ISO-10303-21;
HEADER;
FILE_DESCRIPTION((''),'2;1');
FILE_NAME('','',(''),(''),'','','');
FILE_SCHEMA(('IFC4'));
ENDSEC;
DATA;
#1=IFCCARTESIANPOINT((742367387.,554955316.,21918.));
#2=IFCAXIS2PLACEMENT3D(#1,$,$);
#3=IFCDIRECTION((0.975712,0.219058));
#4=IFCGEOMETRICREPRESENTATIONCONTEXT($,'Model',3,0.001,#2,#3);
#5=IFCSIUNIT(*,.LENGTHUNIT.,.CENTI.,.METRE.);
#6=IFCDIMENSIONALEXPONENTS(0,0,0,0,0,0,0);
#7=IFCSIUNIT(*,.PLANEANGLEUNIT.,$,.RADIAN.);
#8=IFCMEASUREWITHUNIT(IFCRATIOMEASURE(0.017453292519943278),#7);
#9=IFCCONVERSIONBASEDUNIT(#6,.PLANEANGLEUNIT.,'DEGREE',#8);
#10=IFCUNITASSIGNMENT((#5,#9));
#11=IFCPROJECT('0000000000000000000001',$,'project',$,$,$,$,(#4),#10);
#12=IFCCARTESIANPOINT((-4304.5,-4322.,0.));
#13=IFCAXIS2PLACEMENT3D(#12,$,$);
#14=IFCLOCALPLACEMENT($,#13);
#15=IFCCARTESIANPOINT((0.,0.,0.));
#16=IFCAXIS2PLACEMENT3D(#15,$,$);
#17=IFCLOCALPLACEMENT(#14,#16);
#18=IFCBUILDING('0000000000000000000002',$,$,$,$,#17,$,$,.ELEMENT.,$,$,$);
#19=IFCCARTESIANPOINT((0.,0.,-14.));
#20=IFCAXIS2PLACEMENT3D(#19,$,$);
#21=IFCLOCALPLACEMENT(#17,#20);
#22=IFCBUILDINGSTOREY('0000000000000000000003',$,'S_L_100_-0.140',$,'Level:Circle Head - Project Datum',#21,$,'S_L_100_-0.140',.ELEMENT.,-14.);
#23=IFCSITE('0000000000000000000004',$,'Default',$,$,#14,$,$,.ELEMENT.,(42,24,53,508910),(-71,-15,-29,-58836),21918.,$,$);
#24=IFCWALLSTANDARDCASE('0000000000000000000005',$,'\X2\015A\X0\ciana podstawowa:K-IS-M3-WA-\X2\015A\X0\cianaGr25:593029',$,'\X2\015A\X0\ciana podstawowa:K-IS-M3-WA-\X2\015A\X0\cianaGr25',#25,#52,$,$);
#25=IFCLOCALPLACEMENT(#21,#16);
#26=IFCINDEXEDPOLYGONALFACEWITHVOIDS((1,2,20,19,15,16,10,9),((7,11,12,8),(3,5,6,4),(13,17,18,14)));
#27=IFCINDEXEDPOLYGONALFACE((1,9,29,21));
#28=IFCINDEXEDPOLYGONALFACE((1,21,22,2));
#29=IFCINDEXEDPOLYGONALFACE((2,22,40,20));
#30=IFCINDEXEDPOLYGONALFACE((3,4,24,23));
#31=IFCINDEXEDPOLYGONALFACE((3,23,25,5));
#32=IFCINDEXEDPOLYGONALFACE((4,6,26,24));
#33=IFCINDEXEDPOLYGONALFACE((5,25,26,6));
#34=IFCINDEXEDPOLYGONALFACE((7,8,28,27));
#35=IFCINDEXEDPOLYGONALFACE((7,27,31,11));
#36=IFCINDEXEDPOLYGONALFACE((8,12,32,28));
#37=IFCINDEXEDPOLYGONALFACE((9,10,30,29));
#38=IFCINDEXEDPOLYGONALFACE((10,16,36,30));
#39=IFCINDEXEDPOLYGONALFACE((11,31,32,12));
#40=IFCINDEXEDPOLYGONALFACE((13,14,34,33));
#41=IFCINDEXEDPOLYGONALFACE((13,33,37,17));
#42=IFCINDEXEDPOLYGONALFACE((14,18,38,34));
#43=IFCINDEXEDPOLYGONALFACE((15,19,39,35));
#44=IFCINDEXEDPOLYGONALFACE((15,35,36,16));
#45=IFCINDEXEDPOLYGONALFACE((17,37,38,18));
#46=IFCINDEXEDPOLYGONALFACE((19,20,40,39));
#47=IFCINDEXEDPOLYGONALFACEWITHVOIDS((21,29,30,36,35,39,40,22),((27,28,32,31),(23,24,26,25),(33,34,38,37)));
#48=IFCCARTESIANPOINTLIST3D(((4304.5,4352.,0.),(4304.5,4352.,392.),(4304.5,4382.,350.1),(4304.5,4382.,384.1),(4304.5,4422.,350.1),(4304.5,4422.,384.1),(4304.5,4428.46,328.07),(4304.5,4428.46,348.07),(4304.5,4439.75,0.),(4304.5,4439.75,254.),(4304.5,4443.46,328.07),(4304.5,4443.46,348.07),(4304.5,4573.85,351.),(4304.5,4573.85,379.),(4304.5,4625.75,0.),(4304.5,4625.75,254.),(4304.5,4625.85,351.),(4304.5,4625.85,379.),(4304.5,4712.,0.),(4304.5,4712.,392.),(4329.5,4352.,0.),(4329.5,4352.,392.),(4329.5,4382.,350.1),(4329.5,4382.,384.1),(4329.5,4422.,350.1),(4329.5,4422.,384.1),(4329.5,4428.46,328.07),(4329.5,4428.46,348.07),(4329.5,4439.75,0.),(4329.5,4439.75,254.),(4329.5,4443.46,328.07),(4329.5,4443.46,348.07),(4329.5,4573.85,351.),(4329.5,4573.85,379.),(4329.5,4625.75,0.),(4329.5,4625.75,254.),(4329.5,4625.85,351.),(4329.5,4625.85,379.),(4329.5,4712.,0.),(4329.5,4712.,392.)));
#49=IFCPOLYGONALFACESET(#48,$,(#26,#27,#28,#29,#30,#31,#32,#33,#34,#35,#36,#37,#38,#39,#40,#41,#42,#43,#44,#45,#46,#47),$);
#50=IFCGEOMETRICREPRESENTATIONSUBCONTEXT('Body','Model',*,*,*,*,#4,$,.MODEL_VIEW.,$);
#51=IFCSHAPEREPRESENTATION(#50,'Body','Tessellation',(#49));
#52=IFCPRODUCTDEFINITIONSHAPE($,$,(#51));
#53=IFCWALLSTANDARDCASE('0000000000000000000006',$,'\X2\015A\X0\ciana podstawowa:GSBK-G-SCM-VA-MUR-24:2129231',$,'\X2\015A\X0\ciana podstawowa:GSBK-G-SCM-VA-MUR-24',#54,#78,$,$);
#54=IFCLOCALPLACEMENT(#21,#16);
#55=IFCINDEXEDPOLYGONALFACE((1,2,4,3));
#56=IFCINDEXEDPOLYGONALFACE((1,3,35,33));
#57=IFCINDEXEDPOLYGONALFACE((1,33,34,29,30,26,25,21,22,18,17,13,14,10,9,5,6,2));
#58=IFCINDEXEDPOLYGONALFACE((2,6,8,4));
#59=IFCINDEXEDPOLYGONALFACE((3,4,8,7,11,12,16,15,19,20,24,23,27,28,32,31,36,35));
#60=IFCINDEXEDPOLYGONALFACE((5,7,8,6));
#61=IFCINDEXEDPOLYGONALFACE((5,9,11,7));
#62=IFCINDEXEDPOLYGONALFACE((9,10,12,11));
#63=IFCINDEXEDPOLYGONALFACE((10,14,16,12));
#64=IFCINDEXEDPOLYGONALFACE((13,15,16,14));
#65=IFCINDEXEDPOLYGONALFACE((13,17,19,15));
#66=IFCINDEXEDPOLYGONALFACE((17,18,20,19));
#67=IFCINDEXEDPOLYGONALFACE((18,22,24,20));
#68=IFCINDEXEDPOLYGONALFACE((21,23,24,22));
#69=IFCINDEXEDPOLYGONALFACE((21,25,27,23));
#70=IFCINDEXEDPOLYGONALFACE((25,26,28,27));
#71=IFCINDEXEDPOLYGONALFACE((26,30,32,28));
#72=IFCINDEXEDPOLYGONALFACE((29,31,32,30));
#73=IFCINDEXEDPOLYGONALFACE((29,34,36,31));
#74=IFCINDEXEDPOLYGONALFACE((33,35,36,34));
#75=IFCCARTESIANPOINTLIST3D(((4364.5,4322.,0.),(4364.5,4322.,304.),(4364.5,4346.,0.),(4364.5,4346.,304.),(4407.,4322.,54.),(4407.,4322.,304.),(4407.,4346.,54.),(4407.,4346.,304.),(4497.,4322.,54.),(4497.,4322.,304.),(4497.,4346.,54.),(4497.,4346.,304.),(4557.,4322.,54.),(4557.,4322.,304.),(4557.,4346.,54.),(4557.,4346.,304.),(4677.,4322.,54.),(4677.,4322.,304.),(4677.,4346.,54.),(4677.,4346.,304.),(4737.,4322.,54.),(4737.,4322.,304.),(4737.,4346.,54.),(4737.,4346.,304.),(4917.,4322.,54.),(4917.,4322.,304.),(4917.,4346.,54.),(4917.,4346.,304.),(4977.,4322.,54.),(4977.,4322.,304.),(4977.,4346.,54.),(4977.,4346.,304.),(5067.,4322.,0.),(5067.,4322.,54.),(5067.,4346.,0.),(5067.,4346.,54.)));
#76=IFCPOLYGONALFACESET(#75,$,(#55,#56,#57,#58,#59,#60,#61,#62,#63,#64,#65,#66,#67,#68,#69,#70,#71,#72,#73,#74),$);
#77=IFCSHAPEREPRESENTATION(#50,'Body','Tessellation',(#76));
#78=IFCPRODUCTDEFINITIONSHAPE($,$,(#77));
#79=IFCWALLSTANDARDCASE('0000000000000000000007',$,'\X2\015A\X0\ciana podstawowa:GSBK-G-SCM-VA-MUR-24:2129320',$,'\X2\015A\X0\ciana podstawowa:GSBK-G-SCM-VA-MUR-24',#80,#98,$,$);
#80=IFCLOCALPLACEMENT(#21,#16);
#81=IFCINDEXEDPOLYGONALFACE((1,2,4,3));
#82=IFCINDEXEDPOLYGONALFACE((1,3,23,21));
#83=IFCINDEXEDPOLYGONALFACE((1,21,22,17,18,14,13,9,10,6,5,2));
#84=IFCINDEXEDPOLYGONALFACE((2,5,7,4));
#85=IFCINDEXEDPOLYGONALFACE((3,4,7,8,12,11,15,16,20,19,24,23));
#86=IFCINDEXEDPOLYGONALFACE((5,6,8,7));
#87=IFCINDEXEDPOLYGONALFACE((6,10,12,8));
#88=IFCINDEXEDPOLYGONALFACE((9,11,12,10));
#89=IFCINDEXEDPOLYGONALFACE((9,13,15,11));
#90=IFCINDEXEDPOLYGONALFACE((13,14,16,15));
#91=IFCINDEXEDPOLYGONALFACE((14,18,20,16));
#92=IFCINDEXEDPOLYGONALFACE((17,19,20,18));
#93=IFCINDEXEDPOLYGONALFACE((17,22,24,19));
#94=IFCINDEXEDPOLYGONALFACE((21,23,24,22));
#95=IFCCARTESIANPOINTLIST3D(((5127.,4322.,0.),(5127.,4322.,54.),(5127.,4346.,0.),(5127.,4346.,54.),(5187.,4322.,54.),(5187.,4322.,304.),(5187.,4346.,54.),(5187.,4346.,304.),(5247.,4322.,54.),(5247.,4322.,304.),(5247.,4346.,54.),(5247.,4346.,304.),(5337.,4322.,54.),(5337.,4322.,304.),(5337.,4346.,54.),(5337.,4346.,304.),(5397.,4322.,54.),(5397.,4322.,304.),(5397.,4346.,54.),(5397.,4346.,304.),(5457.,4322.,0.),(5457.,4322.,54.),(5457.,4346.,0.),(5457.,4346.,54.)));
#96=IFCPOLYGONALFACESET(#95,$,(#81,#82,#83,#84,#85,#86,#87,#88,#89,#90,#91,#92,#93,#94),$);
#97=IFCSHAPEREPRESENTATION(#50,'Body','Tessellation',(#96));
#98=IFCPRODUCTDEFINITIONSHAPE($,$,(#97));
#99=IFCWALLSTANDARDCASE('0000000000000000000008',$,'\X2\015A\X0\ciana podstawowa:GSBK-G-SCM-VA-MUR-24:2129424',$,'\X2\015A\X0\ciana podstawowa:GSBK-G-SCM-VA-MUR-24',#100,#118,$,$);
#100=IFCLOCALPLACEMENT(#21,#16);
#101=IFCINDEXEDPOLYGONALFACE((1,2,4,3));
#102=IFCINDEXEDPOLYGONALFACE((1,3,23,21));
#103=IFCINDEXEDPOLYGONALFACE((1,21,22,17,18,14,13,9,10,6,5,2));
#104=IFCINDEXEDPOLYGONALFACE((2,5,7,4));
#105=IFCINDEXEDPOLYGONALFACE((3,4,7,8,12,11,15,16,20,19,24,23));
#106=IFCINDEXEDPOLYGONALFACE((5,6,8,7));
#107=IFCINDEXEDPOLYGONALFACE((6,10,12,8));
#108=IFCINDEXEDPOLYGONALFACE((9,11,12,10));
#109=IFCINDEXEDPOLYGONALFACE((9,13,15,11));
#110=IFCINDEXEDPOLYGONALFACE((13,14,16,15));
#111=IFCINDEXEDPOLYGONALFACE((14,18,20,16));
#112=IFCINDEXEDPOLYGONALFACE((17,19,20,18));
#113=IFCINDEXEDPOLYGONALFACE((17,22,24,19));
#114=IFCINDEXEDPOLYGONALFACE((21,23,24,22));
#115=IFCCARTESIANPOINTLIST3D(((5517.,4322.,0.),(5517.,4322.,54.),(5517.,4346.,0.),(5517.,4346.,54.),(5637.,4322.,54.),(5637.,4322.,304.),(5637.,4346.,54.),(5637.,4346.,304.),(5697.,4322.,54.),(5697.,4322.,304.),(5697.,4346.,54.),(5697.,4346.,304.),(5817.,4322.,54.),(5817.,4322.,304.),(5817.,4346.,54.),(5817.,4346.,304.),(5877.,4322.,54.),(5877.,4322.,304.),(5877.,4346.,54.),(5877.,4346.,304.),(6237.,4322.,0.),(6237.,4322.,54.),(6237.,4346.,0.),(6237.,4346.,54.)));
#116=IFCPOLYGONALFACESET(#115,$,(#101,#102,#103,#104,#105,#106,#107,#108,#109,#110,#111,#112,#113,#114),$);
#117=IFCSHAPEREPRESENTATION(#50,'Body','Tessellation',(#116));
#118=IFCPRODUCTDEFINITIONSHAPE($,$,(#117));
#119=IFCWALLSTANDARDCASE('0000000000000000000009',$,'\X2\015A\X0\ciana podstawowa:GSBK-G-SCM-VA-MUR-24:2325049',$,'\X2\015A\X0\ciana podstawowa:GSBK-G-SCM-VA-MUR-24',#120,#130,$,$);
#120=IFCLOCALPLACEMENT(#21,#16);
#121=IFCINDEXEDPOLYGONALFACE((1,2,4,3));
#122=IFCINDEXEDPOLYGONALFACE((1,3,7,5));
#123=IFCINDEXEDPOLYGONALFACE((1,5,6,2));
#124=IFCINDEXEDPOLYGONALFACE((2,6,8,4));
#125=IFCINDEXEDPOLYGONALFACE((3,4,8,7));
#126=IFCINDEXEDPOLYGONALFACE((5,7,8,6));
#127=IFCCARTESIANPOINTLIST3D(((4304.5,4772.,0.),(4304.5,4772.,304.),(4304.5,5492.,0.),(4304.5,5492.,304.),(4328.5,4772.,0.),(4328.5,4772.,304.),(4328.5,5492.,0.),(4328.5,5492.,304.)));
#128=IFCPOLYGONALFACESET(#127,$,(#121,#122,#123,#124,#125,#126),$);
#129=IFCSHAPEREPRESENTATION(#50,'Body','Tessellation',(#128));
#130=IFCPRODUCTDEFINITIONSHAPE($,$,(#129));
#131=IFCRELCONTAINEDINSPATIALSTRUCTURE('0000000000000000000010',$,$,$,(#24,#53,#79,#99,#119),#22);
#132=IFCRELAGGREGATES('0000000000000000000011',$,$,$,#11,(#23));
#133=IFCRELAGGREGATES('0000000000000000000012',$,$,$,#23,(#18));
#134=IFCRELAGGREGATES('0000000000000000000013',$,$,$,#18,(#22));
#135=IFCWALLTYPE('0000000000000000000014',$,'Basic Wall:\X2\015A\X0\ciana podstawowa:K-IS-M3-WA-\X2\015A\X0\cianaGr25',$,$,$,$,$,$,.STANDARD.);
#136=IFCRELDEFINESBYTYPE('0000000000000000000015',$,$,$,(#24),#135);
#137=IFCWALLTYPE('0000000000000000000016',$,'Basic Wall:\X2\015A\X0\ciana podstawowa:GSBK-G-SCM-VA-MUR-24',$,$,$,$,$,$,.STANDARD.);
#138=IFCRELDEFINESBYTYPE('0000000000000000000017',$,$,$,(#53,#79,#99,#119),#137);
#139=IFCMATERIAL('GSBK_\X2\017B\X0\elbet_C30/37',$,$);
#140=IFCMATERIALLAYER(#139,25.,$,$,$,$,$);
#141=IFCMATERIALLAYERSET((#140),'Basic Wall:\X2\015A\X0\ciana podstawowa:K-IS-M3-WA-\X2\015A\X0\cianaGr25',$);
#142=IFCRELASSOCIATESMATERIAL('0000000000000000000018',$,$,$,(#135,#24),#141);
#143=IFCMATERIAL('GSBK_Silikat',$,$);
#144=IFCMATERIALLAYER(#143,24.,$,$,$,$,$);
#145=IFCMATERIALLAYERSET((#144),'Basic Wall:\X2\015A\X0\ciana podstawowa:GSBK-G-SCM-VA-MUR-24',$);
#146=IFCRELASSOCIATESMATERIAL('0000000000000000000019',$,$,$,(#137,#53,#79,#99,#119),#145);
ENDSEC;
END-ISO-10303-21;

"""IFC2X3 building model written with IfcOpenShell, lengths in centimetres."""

from ifc_helpers import new_model, entity, si_unit, converted_unit, direction, frame, frame_2d, origin, origin_2d_with_axis, place, context, subcontext, project, spatial, rectangle, extrude, material, layer, layer_set, layer_usage, type_object, element, save


model = new_model("IFC2X3")

# Units and contexts
model_context = context("Model", 3, precision=0.001, world=frame((742367387.0, 554955316.0, 21918.0)), true_north=direction((0.975712, 0.219058)))
body_context = subcontext(model_context, "Body", "Model", "MODEL_VIEW")
ifc_project = project(units=[si_unit("LENGTHUNIT", "METRE", prefix="CENTI"), converted_unit("PLANEANGLEUNIT", "DEGREE", entity("IfcRatioMeasure", 0.017453292519943278), si_unit("PLANEANGLEUNIT", "RADIAN"), dimensions=[0, 0, 0, 0, 0, 0, 0])], contexts=[model_context])

# Site, building, storey
site_placement = place(None, frame((-4304.5, -4322.0, 0.0)))
site = spatial("IfcSite", under=ifc_project, at=site_placement, Name="Default", CompositionType="ELEMENT", RefLatitude=(42, 24, 53, 508910), RefLongitude=(-71, -15, -29, -58836), RefElevation=21918.0)
building_placement = place(site_placement, origin())
building = spatial("IfcBuilding", under=site, at=building_placement, CompositionType="ELEMENT")
storey_placement = place(building_placement, frame((0.0, 0.0, -14.0)))
storey = spatial("IfcBuildingStorey", under=building, at=storey_placement, Name="S_L_100_-0.140", ObjectType="Level:Circle Head - Project Datum", LongName="S_L_100_-0.140", CompositionType="ELEMENT", Elevation=-14.0)

# Shared definitions
ifc_material_1 = material(Name="GSBK_Żelbet_C30/37")

# Walls, openings
ifc_layer_1 = layer(ifc_material_1, 25.0)
ifc_layer_set_1 = layer_set([ifc_layer_1], Name="Basic Wall:Ściana podstawowa:K-IS-M3-WA-ŚcianaGr25")
ifc_layer_usage_1 = layer_usage(ifc_layer_set_1, "AXIS2", "NEGATIVE", 12.5)
wall_type_1 = type_object("IfcWallType", Name="Basic Wall:Ściana podstawowa:K-IS-M3-WA-ŚcianaGr25", PredefinedType="STANDARD", material=ifc_layer_set_1)
wall_1_placement = place(storey_placement, frame((4317.0, 4712.0, 0.0), z_axis=(0.0, 0.0, 1.0), x_axis=(0.0, -1.0, 0.0)))
wall_1 = element("IfcWallStandardCase", 1, at=wall_1_placement, inside=storey, type_object=wall_type_1, material=ifc_layer_usage_1, Name="Ściana podstawowa:K-IS-M3-WA-ŚcianaGr25:593029", ObjectType="Ściana podstawowa:K-IS-M3-WA-ŚcianaGr25", context=body_context, shape_type="SweptSolid", body=[
    extrude(rectangle(XDim=360.0, YDim=25.0, at=frame_2d((180.0, 0.0), x_axis=(-1.0, 0.0))), origin(), (0.0, 0.0, 1.0), 392.0),
])
opening_1_placement = place(wall_1_placement, frame((272.25, -12.5, 0.0)))
element("IfcOpeningElement", 2, at=opening_1_placement, cuts=wall_1, ObjectType="Opening", context=body_context, shape_type="SweptSolid", body=[
    extrude(rectangle(XDim=254.0, YDim=186.0, at=origin_2d_with_axis()), frame((-93.0, 0.0, 127.0), z_axis=(0.0, 1.0, 0.0), x_axis=(0.0, 0.0, -1.0)), (0.0, 0.0, 1.0), 25.0),
])
opening_2_placement = place(wall_1_placement, frame((138.15, -12.5, 351.0)))
element("IfcOpeningElement", 3, at=opening_2_placement, cuts=wall_1, ObjectType="Opening", context=body_context, shape_type="SweptSolid", body=[
    extrude(rectangle(XDim=28.0, YDim=52.0, at=frame_2d((0.0, 0.0), x_axis=(1.0, 0.0))), frame((-26.0, 0.0, 14.0), z_axis=(0.0, 1.0, 0.0), x_axis=(0.0, 0.0, -1.0)), (0.0, 0.0, 1.0), 25.0),
])
opening_3_placement = place(wall_1_placement, frame((330.0, -12.5, 350.1)))
element("IfcOpeningElement", 4, at=opening_3_placement, cuts=wall_1, ObjectType="Opening", context=body_context, shape_type="SweptSolid", body=[
    extrude(rectangle(XDim=34.0, YDim=40.0, at=frame_2d((0.0, 0.0), x_axis=(1.0, 0.0))), frame((-20.0, 0.0, 17.0), z_axis=(0.0, 1.0, 0.0), x_axis=(0.0, 0.0, -1.0)), (0.0, 0.0, 1.0), 25.0),
])
opening_4_placement = place(wall_1_placement, frame((283.54, -12.5, 328.07)))
element("IfcOpeningElement", 5, at=opening_4_placement, cuts=wall_1, ObjectType="Opening", context=body_context, shape_type="SweptSolid", body=[
    extrude(rectangle(XDim=20.0, YDim=15.0, at=frame_2d((0.0, 0.0), x_axis=(1.0, 0.0))), frame((-7.5, 0.0, 10.0), z_axis=(0.0, 1.0, 0.0), x_axis=(0.0, 0.0, -1.0)), (0.0, 0.0, 1.0), 25.0),
])
ifc_material_2 = material(Name="GSBK_Silikat")
ifc_layer_2 = layer(ifc_material_2, 24.0)
ifc_layer_set_2 = layer_set([ifc_layer_2], Name="Basic Wall:Ściana podstawowa:GSBK-G-SCM-VA-MUR-24")
ifc_layer_usage_2 = layer_usage(ifc_layer_set_2, "AXIS2", "NEGATIVE", 12.0)
wall_type_2 = type_object("IfcWallType", Name="Basic Wall:Ściana podstawowa:GSBK-G-SCM-VA-MUR-24", PredefinedType="STANDARD", material=ifc_layer_set_2)
wall_2_placement = place(storey_placement, frame((4364.5, 4334.0, 0.0)))
wall_2 = element("IfcWallStandardCase", 6, at=wall_2_placement, inside=storey, type_object=wall_type_2, material=ifc_layer_usage_2, Name="Ściana podstawowa:GSBK-G-SCM-VA-MUR-24:2129231", ObjectType="Ściana podstawowa:GSBK-G-SCM-VA-MUR-24", context=body_context, shape_type="SweptSolid", body=[
    extrude(rectangle(XDim=702.5, YDim=24.0, at=frame_2d((351.25, 0.0), x_axis=(-1.0, 0.0))), origin(), (0.0, 0.0, 1.0), 304.0),
])
opening_5_placement = place(wall_2_placement, frame((192.5, -12.0, 54.0)))
element("IfcOpeningElement", 7, at=opening_5_placement, cuts=wall_2, ObjectType="Opening", context=body_context, shape_type="SweptSolid", body=[
    extrude(rectangle(XDim=250.0, YDim=120.0, at=frame_2d((0.0, 0.0), x_axis=(1.0, 0.0))), frame((60.0, 0.0, 125.0), z_axis=(0.0, 1.0, 0.0), x_axis=(0.0, 0.0, -1.0)), (0.0, 0.0, 1.0), 24.0),
])
opening_6_placement = place(wall_2_placement, frame((612.5, -12.0, 54.0)))
element("IfcOpeningElement", 8, at=opening_6_placement, cuts=wall_2, ObjectType="Opening", context=body_context, shape_type="SweptSolid", body=[
    extrude(rectangle(XDim=250.0, YDim=90.0, at=origin_2d_with_axis()), frame((45.0, 0.0, 125.0), z_axis=(0.0, 1.0, 0.0), x_axis=(0.0, 0.0, -1.0)), (0.0, 0.0, 1.0), 24.0),
])
opening_7_placement = place(wall_2_placement, frame((42.5, -12.0, 54.0)))
element("IfcOpeningElement", 9, at=opening_7_placement, cuts=wall_2, ObjectType="Opening", context=body_context, shape_type="SweptSolid", body=[
    extrude(rectangle(XDim=250.0, YDim=90.0, at=frame_2d((0.0, 0.0), x_axis=(1.0, 0.0))), frame((45.0, 0.0, 125.0), z_axis=(0.0, 1.0, 0.0), x_axis=(0.0, 0.0, -1.0)), (0.0, 0.0, 1.0), 24.0),
])
opening_8_placement = place(wall_2_placement, frame((372.5, -12.0, 54.0)))
element("IfcOpeningElement", 10, at=opening_8_placement, cuts=wall_2, ObjectType="Opening", context=body_context, shape_type="SweptSolid", body=[
    extrude(rectangle(XDim=250.0, YDim=180.0, at=frame_2d((0.0, 0.0), x_axis=(1.0, 0.0))), frame((90.0, 0.0, 125.0), z_axis=(0.0, 1.0, 0.0), x_axis=(0.0, 0.0, -1.0)), (0.0, 0.0, 1.0), 24.0),
])
ifc_layer_usage_3 = layer_usage(ifc_layer_set_2, "AXIS2", "NEGATIVE", 12.0)
wall_3_placement = place(storey_placement, frame((5127.0, 4334.0, 0.0)))
wall_3 = element("IfcWallStandardCase", 11, at=wall_3_placement, inside=storey, type_object=wall_type_2, material=ifc_layer_usage_3, Name="Ściana podstawowa:GSBK-G-SCM-VA-MUR-24:2129320", ObjectType="Ściana podstawowa:GSBK-G-SCM-VA-MUR-24", context=body_context, shape_type="SweptSolid", body=[
    extrude(rectangle(XDim=330.0, YDim=24.0, at=frame_2d((165.0, 0.0), x_axis=(-1.0, 0.0))), origin(), (0.0, 0.0, 1.0), 304.0),
])
opening_9_placement = place(wall_3_placement, frame((120.0, -12.0, 54.0)))
element("IfcOpeningElement", 12, at=opening_9_placement, cuts=wall_3, ObjectType="Opening", context=body_context, shape_type="SweptSolid", body=[
    extrude(rectangle(XDim=250.0, YDim=90.0, at=origin_2d_with_axis()), frame((45.0, 0.0, 125.0), z_axis=(0.0, 1.0, 0.0), x_axis=(0.0, 0.0, -1.0)), (0.0, 0.0, 1.0), 24.0),
])
opening_10_placement = place(wall_3_placement, frame((0.0, -12.0, 54.0)))
element("IfcOpeningElement", 13, at=opening_10_placement, cuts=wall_3, ObjectType="Opening", context=body_context, shape_type="SweptSolid", body=[
    extrude(rectangle(XDim=250.0, YDim=60.0, at=frame_2d((0.0, 0.0), x_axis=(1.0, 0.0))), frame((30.0, 0.0, 125.0), z_axis=(0.0, 1.0, 0.0), x_axis=(0.0, 0.0, -1.0)), (0.0, 0.0, 1.0), 24.0),
])
opening_11_placement = place(wall_3_placement, frame((270.0, -12.0, 54.0)))
element("IfcOpeningElement", 14, at=opening_11_placement, cuts=wall_3, ObjectType="Opening", context=body_context, shape_type="SweptSolid", body=[
    extrude(rectangle(XDim=250.0, YDim=60.0, at=origin_2d_with_axis()), frame((30.0, 0.0, 125.0), z_axis=(0.0, 1.0, 0.0), x_axis=(0.0, 0.0, -1.0)), (0.0, 0.0, 1.0), 24.0),
])
ifc_layer_usage_4 = layer_usage(ifc_layer_set_2, "AXIS2", "NEGATIVE", 12.0)
wall_4_placement = place(storey_placement, frame((5517.0, 4334.0, 0.0)))
wall_4 = element("IfcWallStandardCase", 15, at=wall_4_placement, inside=storey, type_object=wall_type_2, material=ifc_layer_usage_4, Name="Ściana podstawowa:GSBK-G-SCM-VA-MUR-24:2129424", ObjectType="Ściana podstawowa:GSBK-G-SCM-VA-MUR-24", context=body_context, shape_type="SweptSolid", body=[
    extrude(rectangle(XDim=720.0, YDim=24.0, at=frame_2d((360.0, 0.0), x_axis=(-1.0, 0.0))), origin(), (0.0, 0.0, 1.0), 304.0),
])
opening_12_placement = place(wall_4_placement, frame((180.0, -12.0, 54.0)))
element("IfcOpeningElement", 16, at=opening_12_placement, cuts=wall_4, ObjectType="Opening", context=body_context, shape_type="SweptSolid", body=[
    extrude(rectangle(XDim=250.0, YDim=120.0, at=origin_2d_with_axis()), frame((60.0, 0.0, 125.0), z_axis=(0.0, 1.0, 0.0), x_axis=(0.0, 0.0, -1.0)), (0.0, 0.0, 1.0), 24.0),
])
opening_13_placement = place(wall_4_placement, frame((0.0, -12.0, 54.0)))
element("IfcOpeningElement", 17, at=opening_13_placement, cuts=wall_4, ObjectType="Opening", context=body_context, shape_type="SweptSolid", body=[
    extrude(rectangle(XDim=250.0, YDim=120.0, at=frame_2d((0.0, 0.0), x_axis=(1.0, 0.0))), frame((60.0, 0.0, 125.0), z_axis=(0.0, 1.0, 0.0), x_axis=(0.0, 0.0, -1.0)), (0.0, 0.0, 1.0), 24.0),
])
opening_14_placement = place(wall_4_placement, frame((360.0, -12.0, 54.0)))
element("IfcOpeningElement", 18, at=opening_14_placement, cuts=wall_4, ObjectType="Opening", context=body_context, shape_type="SweptSolid", body=[
    extrude(rectangle(XDim=250.0, YDim=360.0, at=frame_2d((0.0, 0.0), x_axis=(1.0, 0.0))), frame((180.0, 0.0, 125.0), z_axis=(0.0, 1.0, 0.0), x_axis=(0.0, 0.0, -1.0)), (0.0, 0.0, 1.0), 24.0),
])

# Wall
ifc_layer_usage_5 = layer_usage(ifc_layer_set_2, "AXIS2", "NEGATIVE", 12.0)
wall_5_placement = place(storey_placement, frame((4316.5, 4772.0, 0.0), z_axis=(0.0, 0.0, 1.0), x_axis=(0.0, 1.0, 0.0)))
element("IfcWallStandardCase", 19, at=wall_5_placement, inside=storey, type_object=wall_type_2, material=ifc_layer_usage_5, Name="Ściana podstawowa:GSBK-G-SCM-VA-MUR-24:2325049", ObjectType="Ściana podstawowa:GSBK-G-SCM-VA-MUR-24", context=body_context, shape_type="SweptSolid", body=[
    extrude(rectangle(XDim=720.0, YDim=24.0, at=frame_2d((360.0, 0.0), x_axis=(-1.0, 0.0))), origin(), (0.0, 0.0, 1.0), 304.0),
])

save(model, "model.ifc")
